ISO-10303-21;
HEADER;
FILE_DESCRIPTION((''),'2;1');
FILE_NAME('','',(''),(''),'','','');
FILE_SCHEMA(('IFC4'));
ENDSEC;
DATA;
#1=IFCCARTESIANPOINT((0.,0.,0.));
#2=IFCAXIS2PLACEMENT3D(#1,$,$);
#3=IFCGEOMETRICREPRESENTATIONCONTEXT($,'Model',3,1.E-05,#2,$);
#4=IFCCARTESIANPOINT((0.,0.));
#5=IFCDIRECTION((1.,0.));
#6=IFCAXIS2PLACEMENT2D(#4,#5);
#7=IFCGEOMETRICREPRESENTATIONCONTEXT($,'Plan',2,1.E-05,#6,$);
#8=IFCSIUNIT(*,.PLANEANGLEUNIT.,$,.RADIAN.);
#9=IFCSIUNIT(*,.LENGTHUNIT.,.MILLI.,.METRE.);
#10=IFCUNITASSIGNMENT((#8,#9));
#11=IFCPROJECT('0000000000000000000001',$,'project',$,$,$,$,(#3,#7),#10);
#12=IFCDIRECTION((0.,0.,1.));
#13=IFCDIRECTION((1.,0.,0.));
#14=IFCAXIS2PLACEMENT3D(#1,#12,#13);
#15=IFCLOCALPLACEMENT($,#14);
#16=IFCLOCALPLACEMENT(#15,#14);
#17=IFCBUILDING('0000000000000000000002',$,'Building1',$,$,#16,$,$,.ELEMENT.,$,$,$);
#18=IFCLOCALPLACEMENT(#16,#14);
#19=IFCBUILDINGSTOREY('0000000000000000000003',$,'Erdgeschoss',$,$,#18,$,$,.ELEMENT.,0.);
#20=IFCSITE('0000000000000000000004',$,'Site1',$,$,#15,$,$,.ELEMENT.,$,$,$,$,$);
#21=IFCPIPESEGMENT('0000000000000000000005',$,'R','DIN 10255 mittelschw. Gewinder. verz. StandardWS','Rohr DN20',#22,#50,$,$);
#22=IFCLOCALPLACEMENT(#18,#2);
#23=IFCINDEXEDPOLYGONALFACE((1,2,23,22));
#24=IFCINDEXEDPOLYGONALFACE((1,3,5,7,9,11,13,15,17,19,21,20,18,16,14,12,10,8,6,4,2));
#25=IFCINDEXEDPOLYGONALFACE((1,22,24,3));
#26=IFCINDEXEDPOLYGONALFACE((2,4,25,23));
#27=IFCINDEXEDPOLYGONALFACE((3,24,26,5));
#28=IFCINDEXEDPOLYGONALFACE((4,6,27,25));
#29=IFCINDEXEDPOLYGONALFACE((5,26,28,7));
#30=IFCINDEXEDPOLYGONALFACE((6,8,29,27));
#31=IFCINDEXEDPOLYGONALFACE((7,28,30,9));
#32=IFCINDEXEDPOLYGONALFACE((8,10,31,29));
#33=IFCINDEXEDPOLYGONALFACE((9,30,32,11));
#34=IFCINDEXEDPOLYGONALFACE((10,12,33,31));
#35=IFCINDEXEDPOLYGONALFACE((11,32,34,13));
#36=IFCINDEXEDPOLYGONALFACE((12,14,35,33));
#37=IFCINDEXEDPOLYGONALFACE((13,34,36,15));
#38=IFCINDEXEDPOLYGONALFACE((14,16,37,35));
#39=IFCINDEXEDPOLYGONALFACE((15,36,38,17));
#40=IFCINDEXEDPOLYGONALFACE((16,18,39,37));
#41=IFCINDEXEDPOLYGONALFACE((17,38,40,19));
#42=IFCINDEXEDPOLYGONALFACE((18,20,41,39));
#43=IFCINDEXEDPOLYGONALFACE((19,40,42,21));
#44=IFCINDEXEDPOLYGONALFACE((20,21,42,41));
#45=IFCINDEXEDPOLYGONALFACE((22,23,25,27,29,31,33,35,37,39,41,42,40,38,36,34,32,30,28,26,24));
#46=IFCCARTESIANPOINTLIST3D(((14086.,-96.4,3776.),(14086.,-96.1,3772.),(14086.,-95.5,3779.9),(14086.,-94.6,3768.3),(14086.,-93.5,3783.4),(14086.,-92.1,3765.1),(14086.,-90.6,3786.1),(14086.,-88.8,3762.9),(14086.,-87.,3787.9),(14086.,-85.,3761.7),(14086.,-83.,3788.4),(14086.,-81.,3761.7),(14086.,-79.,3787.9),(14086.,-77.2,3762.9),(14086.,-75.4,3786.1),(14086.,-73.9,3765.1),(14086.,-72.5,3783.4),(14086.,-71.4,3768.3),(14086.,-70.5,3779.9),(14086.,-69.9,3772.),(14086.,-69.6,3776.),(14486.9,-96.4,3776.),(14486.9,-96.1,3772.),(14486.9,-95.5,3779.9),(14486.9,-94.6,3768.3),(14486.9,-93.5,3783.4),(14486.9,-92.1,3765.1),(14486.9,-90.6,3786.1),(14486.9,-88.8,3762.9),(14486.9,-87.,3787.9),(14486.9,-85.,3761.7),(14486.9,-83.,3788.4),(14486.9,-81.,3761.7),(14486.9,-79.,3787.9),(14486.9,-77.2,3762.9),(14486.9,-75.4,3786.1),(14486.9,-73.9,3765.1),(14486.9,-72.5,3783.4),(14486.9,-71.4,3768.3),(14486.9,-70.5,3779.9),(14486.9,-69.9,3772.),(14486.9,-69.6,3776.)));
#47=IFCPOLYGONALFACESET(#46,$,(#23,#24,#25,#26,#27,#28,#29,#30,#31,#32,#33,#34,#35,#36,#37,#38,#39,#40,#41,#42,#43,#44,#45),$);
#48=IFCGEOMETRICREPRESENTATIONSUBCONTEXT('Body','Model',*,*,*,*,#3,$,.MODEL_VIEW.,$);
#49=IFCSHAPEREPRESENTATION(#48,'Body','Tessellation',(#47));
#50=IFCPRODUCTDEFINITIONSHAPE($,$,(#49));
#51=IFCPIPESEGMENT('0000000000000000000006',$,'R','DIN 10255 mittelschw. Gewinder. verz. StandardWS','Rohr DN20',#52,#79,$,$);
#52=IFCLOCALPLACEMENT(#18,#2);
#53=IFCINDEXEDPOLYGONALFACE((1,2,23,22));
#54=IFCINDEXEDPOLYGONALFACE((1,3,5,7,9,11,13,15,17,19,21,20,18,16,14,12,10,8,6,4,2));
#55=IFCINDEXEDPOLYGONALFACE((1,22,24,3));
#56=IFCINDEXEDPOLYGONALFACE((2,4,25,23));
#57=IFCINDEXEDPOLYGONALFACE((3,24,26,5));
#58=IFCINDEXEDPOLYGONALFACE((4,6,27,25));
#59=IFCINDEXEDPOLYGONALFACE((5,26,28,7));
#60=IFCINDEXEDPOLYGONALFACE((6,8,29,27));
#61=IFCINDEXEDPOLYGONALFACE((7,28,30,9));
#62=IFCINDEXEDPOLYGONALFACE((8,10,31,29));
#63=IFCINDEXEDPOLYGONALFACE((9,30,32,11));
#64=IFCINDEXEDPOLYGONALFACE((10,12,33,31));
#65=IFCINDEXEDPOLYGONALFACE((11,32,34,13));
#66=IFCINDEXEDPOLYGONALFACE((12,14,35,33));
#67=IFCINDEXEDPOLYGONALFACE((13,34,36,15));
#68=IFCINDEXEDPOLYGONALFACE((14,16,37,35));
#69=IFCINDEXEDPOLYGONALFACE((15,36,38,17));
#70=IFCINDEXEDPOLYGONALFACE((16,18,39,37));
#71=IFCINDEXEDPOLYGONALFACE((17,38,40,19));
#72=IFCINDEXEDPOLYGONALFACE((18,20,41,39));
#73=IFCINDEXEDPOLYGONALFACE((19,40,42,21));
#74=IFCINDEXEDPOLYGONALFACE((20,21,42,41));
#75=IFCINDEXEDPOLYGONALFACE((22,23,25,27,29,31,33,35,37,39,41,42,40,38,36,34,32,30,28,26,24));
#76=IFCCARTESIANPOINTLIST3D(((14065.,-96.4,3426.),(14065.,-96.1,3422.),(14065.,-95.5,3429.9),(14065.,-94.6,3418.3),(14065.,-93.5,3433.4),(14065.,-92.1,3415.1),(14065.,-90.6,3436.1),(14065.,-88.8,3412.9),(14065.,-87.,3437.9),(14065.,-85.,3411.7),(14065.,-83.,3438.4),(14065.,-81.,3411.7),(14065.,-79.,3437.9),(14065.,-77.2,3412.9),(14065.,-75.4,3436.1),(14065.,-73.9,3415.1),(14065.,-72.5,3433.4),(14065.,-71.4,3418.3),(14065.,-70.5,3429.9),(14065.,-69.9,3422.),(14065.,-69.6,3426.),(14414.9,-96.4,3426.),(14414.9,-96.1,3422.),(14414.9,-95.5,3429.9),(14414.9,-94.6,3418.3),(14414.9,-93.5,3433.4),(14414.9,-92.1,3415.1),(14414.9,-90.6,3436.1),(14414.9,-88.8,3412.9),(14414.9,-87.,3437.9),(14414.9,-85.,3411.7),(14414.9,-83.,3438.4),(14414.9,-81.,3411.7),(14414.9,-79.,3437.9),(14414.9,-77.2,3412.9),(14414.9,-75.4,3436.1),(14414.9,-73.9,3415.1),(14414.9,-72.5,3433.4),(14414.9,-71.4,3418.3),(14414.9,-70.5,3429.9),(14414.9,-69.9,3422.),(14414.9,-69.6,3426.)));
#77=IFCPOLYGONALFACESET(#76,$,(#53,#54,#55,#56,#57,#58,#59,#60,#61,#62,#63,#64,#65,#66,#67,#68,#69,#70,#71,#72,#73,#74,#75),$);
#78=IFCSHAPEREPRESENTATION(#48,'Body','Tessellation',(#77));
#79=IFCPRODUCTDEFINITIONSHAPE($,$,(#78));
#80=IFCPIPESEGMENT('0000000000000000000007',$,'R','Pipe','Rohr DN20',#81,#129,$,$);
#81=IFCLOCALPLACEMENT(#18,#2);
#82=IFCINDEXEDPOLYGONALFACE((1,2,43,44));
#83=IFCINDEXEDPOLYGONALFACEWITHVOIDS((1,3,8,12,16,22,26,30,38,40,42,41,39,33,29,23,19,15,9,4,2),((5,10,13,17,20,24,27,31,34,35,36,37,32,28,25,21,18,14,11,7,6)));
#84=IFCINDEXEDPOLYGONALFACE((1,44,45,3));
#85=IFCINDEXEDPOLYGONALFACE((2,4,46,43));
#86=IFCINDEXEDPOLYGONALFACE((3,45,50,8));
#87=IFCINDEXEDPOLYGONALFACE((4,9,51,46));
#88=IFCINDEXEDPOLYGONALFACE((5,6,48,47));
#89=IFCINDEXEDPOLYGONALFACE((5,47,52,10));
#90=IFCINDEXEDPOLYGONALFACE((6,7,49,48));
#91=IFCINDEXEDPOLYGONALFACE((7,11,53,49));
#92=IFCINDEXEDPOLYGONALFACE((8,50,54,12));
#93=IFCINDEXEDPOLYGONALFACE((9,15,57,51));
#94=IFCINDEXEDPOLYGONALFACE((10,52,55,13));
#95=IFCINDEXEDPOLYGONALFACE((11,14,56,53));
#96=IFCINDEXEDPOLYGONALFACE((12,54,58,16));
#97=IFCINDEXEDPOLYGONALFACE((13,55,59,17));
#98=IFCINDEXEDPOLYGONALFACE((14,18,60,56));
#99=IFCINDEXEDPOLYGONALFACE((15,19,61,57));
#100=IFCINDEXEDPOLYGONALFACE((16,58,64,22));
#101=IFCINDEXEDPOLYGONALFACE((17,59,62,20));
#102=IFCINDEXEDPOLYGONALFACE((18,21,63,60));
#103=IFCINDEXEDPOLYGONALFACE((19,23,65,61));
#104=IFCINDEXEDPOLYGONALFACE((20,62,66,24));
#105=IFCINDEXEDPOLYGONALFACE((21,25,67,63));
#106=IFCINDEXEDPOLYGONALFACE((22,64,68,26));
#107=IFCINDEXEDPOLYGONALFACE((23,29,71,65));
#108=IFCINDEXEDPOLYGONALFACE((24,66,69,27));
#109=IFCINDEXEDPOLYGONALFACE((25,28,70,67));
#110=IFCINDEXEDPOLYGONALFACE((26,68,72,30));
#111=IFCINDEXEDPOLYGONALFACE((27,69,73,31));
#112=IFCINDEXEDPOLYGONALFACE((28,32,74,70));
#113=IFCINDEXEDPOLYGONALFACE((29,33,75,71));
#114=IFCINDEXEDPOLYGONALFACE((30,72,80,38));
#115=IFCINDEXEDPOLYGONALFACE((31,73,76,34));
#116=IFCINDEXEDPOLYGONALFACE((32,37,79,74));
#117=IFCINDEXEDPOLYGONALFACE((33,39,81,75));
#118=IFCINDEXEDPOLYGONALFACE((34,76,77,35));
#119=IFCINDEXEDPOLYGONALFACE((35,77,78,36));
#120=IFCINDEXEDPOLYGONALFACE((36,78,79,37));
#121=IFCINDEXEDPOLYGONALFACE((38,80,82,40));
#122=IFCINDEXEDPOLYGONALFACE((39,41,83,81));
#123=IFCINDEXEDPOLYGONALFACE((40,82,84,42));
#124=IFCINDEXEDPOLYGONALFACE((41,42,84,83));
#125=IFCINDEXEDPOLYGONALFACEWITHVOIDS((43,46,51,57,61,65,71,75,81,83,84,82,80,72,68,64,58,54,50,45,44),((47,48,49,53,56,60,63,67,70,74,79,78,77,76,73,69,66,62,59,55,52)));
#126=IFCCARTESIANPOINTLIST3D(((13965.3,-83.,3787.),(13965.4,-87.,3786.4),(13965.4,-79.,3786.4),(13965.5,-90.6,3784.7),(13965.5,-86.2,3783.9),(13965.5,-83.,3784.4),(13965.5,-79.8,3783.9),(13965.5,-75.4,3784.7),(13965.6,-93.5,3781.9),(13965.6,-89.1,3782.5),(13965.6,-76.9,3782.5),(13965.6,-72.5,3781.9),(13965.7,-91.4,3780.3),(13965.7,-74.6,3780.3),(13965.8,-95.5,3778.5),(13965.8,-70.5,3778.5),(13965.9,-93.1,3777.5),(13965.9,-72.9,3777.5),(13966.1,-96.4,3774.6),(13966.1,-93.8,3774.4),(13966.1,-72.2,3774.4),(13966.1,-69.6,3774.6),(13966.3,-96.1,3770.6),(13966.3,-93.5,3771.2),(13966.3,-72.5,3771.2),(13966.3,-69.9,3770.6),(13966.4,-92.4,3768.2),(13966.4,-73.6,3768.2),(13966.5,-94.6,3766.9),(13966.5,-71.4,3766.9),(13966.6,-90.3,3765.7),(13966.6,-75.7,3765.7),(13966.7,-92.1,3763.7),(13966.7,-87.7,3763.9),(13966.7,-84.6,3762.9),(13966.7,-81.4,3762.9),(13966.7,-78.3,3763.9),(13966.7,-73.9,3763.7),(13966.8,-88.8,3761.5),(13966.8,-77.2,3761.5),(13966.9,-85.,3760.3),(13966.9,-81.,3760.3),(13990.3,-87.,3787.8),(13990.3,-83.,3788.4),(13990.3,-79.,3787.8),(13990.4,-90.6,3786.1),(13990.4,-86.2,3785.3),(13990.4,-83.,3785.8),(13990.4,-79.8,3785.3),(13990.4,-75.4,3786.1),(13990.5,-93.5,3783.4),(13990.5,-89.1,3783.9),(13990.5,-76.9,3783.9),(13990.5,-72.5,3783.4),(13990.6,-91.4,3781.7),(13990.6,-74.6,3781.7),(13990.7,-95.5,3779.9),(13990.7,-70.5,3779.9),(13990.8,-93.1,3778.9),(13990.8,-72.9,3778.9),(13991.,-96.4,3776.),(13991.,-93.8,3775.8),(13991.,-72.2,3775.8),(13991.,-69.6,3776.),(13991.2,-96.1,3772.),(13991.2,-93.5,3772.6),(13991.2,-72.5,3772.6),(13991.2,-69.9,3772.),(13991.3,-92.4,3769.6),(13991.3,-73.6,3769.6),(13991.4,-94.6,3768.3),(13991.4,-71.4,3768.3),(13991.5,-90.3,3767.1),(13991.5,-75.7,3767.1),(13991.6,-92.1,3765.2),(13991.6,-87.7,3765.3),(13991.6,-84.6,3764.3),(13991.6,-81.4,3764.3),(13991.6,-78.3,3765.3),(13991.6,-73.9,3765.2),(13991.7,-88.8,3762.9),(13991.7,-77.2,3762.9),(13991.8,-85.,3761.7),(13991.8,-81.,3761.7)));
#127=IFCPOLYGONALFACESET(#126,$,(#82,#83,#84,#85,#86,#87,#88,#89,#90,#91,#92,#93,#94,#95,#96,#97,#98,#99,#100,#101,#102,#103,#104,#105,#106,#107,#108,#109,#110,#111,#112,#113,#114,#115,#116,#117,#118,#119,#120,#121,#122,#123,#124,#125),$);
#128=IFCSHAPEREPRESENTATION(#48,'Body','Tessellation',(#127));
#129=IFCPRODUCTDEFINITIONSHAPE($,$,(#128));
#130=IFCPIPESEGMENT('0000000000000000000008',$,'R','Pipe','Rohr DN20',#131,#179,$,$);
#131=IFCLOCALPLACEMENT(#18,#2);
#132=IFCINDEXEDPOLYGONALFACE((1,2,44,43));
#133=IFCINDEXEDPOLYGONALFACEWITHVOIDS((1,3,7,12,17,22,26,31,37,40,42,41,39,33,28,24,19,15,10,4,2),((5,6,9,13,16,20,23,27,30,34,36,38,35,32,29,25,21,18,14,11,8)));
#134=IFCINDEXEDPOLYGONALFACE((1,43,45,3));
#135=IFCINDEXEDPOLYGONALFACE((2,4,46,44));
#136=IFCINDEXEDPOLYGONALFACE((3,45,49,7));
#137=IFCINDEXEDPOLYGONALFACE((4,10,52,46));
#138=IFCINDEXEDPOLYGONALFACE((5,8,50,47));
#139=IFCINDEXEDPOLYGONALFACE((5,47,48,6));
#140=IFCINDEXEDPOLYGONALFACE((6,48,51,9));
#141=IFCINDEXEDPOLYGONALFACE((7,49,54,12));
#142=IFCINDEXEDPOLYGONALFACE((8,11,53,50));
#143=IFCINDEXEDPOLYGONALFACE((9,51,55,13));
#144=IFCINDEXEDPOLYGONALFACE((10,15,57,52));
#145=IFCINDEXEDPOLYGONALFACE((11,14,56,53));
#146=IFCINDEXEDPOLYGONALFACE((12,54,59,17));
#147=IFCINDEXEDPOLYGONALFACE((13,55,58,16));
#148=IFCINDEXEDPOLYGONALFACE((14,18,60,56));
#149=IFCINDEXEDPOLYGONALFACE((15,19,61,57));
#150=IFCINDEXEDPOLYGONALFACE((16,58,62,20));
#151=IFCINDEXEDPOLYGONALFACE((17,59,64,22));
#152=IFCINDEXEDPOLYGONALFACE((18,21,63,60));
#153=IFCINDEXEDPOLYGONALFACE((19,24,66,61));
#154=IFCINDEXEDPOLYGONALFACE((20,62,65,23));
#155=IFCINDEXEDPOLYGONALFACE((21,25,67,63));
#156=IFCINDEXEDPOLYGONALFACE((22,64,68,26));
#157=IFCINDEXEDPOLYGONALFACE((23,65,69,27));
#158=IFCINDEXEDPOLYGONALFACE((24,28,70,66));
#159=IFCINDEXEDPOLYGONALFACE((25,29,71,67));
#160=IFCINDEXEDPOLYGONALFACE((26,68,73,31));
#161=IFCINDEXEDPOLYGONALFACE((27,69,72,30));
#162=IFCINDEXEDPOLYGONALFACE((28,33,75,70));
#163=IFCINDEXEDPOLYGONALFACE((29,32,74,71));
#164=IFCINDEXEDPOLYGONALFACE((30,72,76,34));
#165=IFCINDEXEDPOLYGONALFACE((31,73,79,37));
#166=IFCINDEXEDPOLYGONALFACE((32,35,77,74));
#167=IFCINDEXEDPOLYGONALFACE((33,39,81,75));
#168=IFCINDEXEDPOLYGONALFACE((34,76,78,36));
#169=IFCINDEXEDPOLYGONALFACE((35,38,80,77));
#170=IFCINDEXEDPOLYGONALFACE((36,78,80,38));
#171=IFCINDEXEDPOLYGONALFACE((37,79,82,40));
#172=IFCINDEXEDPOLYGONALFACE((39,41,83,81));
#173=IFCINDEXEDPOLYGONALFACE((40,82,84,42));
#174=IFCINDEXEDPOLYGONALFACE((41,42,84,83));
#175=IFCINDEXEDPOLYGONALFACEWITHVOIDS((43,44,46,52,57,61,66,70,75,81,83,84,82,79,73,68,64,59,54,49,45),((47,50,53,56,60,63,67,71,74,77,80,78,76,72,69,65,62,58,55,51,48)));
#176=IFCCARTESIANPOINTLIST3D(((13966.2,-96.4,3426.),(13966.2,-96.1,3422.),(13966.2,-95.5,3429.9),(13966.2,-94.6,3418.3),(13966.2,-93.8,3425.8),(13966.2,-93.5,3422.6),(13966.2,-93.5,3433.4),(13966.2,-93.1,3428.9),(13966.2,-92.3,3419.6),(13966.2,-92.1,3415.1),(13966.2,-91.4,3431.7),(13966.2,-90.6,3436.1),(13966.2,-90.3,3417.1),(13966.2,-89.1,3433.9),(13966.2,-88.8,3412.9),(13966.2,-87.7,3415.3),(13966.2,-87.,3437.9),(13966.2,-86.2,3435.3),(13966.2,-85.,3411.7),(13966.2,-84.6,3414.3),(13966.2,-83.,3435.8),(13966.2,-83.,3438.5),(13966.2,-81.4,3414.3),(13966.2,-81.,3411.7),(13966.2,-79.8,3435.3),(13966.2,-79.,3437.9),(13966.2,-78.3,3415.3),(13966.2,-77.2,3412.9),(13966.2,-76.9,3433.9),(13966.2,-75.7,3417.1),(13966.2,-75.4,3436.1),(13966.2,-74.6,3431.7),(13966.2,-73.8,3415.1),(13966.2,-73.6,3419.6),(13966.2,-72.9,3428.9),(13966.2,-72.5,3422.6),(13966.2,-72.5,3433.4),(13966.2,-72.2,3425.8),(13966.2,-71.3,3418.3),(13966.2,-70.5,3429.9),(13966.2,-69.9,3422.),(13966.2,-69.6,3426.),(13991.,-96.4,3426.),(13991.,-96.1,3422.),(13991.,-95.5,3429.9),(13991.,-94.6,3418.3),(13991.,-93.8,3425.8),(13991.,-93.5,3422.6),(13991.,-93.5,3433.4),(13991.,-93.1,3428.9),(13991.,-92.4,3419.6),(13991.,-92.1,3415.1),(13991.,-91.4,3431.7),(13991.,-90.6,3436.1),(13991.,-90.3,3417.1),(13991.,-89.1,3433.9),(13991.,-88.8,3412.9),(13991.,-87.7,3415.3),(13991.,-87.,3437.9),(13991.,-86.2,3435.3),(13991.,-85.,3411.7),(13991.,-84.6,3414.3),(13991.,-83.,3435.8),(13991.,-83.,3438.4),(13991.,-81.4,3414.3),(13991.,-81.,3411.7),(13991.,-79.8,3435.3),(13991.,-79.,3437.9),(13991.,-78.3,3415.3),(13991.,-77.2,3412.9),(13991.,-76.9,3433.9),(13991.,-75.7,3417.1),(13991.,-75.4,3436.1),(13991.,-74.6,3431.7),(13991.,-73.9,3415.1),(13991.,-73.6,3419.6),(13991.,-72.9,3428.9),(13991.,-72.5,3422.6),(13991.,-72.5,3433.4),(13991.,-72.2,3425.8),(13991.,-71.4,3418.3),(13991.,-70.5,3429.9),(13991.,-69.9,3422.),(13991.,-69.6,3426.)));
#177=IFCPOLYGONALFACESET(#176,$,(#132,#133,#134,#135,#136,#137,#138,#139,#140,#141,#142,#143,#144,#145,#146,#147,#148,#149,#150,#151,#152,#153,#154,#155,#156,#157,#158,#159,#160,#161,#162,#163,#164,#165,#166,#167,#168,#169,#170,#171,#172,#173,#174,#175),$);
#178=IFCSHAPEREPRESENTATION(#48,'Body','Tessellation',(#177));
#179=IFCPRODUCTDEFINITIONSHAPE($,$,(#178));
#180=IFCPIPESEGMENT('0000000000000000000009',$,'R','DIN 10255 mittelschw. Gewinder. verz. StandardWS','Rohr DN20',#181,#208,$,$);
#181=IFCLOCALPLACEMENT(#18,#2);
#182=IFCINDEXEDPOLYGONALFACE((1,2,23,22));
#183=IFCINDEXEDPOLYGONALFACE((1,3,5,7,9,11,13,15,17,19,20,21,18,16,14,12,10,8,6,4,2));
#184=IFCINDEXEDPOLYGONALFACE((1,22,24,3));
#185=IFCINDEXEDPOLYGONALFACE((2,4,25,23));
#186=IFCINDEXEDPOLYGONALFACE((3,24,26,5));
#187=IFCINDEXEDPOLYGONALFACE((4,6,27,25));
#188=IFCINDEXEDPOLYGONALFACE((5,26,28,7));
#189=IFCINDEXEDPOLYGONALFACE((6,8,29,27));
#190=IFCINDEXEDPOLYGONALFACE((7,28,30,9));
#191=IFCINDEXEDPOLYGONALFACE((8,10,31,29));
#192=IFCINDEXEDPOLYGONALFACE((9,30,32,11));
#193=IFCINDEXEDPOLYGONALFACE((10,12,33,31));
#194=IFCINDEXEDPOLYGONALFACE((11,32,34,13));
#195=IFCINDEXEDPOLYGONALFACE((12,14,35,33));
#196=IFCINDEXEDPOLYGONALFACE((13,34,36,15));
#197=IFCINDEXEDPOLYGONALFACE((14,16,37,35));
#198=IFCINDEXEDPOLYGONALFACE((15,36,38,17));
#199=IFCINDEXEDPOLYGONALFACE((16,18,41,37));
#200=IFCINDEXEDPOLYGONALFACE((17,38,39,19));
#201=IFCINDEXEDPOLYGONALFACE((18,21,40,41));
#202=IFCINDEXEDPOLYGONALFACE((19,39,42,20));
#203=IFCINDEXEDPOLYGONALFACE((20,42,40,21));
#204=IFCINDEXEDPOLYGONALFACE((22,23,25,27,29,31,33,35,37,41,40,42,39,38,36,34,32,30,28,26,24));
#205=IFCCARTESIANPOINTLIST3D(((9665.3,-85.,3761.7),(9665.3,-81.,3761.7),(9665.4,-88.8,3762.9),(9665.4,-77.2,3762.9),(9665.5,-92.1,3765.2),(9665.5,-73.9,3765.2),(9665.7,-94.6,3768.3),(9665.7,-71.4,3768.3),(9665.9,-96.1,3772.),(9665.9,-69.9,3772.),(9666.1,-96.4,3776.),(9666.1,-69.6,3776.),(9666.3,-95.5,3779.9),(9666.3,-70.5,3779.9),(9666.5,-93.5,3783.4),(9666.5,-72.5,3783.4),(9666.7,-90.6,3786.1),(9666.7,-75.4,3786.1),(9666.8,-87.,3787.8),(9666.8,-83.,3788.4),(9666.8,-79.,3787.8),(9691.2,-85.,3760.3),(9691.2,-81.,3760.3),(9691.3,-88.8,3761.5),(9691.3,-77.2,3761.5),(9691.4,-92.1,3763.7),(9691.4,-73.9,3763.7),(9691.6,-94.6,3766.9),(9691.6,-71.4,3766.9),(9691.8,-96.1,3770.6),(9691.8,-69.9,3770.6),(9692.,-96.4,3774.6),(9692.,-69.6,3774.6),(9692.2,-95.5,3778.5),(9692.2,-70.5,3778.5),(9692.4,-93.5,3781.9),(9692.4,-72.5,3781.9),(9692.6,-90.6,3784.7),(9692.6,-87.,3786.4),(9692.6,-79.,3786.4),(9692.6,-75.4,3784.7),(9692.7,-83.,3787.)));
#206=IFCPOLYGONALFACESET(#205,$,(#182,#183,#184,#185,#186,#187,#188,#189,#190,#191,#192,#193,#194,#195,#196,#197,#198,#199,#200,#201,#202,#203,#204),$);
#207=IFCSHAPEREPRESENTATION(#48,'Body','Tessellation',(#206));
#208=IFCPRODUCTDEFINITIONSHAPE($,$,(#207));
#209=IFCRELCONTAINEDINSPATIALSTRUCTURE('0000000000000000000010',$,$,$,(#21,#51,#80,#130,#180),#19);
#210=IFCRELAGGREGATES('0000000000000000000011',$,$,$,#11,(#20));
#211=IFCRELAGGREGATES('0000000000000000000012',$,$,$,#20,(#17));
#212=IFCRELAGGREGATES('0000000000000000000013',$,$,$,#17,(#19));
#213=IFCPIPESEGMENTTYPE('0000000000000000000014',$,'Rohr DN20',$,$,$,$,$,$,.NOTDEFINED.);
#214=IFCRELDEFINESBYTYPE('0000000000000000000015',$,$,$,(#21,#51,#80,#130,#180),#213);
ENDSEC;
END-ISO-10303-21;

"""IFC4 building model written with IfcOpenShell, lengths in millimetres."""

from ifc_helpers import new_model, si_unit, frame, origin, origin_with_axes, origin_2d_with_axis, place, context, subcontext, project, spatial, circle, hollow_circle, extrude, type_object, element, save


model = new_model("IFC4")

# Units and contexts
model_context = context("Model", 3, precision=1e-05, world=origin())
plan_context = context("Plan", 2, precision=1e-05, world=origin_2d_with_axis())
body_context = subcontext(model_context, "Body", "Model", "MODEL_VIEW")
ifc_project = project(units=[si_unit("PLANEANGLEUNIT", "RADIAN"), si_unit("LENGTHUNIT", "METRE", prefix="MILLI")], contexts=[model_context, plan_context])

# Site, building, storey
site_placement = place(None, origin_with_axes())
site = spatial("IfcSite", under=ifc_project, at=site_placement, Name="Site1", CompositionType="ELEMENT")
building_placement = place(site_placement, origin_with_axes())
building = spatial("IfcBuilding", under=site, at=building_placement, Name="Building1", CompositionType="ELEMENT")
storey_placement = place(building_placement, origin_with_axes())
storey = spatial("IfcBuildingStorey", under=building, at=storey_placement, Name="Erdgeschoss", CompositionType="ELEMENT", Elevation=0.0)

# Pipe segments
pipe_segment_type_1 = type_object("IfcPipeSegmentType", Name="Rohr DN20", PredefinedType="NOTDEFINED")
pipe_segment_1_placement = place(storey_placement, frame((14286.5, -83.2, 3775.0), z_axis=(0.0, 0.0, 1.0), x_axis=(1.0, 0.0, 0.0)))
element("IfcPipeSegment", 1, at=pipe_segment_1_placement, inside=storey, type_object=pipe_segment_type_1, Name="R", Description="DIN 10255 mittelschw. Gewinder. verz. StandardWS", ObjectType="Rohr DN20", context=body_context, shape_type="SolidModel", body=[
    extrude(circle(Radius=13.4, at=origin_2d_with_axis()), frame((200.5, 0.1, 0.0), z_axis=(-1.0, 0.0, 0.0), x_axis=(0.0, 0.0, 1.0)), (0.0, 0.0, 1.0), 400.9),
])
pipe_segment_2_placement = place(storey_placement, frame((14240.0, -83.2, 3425.0), z_axis=(0.0, 0.0, 1.0), x_axis=(1.0, 0.0, 0.0)))
element("IfcPipeSegment", 2, at=pipe_segment_2_placement, inside=storey, type_object=pipe_segment_type_1, Name="R", Description="DIN 10255 mittelschw. Gewinder. verz. StandardWS", ObjectType="Rohr DN20", context=body_context, shape_type="SolidModel", body=[
    extrude(circle(Radius=13.4, at=origin_2d_with_axis()), frame((175.0, 0.2, 0.0), z_axis=(-1.0, 0.0, 0.0), x_axis=(0.0, 0.0, 1.0)), (0.0, 0.0, 1.0), 349.9),
])
pipe_segment_3_placement = place(storey_placement, frame((13978.6, -82.8, 3774.3), z_axis=(0.0, 0.0, 1.0), x_axis=(1.0, 0.0, 0.0)))
element("IfcPipeSegment", 3, at=pipe_segment_3_placement, inside=storey, type_object=pipe_segment_type_1, Name="R", Description="Pipe", ObjectType="Rohr DN20", context=body_context, shape_type="SolidModel", body=[
    extrude(hollow_circle(Radius=13.4, WallThickness=2.6, at=origin_2d_with_axis()), frame((-12.5, -0.1, -0.7), z_axis=(0.998368, 0.0, 0.057114), x_axis=(0.0, 0.0, 1.0)), (0.0, 0.0, 1.0), 24.9),
])
pipe_segment_4_placement = place(storey_placement, frame((13978.6, -82.8, 3425.0), z_axis=(0.0, 0.0, 1.0), x_axis=(1.0, 0.0, 0.0)))
element("IfcPipeSegment", 4, at=pipe_segment_4_placement, inside=storey, type_object=pipe_segment_type_1, Name="R", Description="Pipe", ObjectType="Rohr DN20", context=body_context, shape_type="SolidModel", body=[
    extrude(hollow_circle(Radius=13.4, WallThickness=2.6, at=origin_2d_with_axis()), frame((-12.4, -0.1, 0.0), z_axis=(1.0, -0.000132, -0.000095), x_axis=(0.0, 0.0, 1.0)), (0.0, 0.0, 1.0), 24.9),
])
pipe_segment_5_placement = place(storey_placement, frame((9679.0, -83.2, 3774.3), z_axis=(0.0, 0.0, 1.0), x_axis=(1.0, 0.0, 0.0)))
element("IfcPipeSegment", 5, at=pipe_segment_5_placement, inside=storey, type_object=pipe_segment_type_1, Name="R", Description="DIN 10255 mittelschw. Gewinder. verz. StandardWS", ObjectType="Rohr DN20", context=body_context, shape_type="SolidModel", body=[
    extrude(circle(Radius=13.4, at=origin_2d_with_axis()), frame((12.9, 0.1, -0.7), z_axis=(-0.99849, 0.0, 0.054935), x_axis=(0.0, 0.0, 1.0)), (0.0, 0.0, 1.0), 25.9),
])

save(model, "model.ifc")
